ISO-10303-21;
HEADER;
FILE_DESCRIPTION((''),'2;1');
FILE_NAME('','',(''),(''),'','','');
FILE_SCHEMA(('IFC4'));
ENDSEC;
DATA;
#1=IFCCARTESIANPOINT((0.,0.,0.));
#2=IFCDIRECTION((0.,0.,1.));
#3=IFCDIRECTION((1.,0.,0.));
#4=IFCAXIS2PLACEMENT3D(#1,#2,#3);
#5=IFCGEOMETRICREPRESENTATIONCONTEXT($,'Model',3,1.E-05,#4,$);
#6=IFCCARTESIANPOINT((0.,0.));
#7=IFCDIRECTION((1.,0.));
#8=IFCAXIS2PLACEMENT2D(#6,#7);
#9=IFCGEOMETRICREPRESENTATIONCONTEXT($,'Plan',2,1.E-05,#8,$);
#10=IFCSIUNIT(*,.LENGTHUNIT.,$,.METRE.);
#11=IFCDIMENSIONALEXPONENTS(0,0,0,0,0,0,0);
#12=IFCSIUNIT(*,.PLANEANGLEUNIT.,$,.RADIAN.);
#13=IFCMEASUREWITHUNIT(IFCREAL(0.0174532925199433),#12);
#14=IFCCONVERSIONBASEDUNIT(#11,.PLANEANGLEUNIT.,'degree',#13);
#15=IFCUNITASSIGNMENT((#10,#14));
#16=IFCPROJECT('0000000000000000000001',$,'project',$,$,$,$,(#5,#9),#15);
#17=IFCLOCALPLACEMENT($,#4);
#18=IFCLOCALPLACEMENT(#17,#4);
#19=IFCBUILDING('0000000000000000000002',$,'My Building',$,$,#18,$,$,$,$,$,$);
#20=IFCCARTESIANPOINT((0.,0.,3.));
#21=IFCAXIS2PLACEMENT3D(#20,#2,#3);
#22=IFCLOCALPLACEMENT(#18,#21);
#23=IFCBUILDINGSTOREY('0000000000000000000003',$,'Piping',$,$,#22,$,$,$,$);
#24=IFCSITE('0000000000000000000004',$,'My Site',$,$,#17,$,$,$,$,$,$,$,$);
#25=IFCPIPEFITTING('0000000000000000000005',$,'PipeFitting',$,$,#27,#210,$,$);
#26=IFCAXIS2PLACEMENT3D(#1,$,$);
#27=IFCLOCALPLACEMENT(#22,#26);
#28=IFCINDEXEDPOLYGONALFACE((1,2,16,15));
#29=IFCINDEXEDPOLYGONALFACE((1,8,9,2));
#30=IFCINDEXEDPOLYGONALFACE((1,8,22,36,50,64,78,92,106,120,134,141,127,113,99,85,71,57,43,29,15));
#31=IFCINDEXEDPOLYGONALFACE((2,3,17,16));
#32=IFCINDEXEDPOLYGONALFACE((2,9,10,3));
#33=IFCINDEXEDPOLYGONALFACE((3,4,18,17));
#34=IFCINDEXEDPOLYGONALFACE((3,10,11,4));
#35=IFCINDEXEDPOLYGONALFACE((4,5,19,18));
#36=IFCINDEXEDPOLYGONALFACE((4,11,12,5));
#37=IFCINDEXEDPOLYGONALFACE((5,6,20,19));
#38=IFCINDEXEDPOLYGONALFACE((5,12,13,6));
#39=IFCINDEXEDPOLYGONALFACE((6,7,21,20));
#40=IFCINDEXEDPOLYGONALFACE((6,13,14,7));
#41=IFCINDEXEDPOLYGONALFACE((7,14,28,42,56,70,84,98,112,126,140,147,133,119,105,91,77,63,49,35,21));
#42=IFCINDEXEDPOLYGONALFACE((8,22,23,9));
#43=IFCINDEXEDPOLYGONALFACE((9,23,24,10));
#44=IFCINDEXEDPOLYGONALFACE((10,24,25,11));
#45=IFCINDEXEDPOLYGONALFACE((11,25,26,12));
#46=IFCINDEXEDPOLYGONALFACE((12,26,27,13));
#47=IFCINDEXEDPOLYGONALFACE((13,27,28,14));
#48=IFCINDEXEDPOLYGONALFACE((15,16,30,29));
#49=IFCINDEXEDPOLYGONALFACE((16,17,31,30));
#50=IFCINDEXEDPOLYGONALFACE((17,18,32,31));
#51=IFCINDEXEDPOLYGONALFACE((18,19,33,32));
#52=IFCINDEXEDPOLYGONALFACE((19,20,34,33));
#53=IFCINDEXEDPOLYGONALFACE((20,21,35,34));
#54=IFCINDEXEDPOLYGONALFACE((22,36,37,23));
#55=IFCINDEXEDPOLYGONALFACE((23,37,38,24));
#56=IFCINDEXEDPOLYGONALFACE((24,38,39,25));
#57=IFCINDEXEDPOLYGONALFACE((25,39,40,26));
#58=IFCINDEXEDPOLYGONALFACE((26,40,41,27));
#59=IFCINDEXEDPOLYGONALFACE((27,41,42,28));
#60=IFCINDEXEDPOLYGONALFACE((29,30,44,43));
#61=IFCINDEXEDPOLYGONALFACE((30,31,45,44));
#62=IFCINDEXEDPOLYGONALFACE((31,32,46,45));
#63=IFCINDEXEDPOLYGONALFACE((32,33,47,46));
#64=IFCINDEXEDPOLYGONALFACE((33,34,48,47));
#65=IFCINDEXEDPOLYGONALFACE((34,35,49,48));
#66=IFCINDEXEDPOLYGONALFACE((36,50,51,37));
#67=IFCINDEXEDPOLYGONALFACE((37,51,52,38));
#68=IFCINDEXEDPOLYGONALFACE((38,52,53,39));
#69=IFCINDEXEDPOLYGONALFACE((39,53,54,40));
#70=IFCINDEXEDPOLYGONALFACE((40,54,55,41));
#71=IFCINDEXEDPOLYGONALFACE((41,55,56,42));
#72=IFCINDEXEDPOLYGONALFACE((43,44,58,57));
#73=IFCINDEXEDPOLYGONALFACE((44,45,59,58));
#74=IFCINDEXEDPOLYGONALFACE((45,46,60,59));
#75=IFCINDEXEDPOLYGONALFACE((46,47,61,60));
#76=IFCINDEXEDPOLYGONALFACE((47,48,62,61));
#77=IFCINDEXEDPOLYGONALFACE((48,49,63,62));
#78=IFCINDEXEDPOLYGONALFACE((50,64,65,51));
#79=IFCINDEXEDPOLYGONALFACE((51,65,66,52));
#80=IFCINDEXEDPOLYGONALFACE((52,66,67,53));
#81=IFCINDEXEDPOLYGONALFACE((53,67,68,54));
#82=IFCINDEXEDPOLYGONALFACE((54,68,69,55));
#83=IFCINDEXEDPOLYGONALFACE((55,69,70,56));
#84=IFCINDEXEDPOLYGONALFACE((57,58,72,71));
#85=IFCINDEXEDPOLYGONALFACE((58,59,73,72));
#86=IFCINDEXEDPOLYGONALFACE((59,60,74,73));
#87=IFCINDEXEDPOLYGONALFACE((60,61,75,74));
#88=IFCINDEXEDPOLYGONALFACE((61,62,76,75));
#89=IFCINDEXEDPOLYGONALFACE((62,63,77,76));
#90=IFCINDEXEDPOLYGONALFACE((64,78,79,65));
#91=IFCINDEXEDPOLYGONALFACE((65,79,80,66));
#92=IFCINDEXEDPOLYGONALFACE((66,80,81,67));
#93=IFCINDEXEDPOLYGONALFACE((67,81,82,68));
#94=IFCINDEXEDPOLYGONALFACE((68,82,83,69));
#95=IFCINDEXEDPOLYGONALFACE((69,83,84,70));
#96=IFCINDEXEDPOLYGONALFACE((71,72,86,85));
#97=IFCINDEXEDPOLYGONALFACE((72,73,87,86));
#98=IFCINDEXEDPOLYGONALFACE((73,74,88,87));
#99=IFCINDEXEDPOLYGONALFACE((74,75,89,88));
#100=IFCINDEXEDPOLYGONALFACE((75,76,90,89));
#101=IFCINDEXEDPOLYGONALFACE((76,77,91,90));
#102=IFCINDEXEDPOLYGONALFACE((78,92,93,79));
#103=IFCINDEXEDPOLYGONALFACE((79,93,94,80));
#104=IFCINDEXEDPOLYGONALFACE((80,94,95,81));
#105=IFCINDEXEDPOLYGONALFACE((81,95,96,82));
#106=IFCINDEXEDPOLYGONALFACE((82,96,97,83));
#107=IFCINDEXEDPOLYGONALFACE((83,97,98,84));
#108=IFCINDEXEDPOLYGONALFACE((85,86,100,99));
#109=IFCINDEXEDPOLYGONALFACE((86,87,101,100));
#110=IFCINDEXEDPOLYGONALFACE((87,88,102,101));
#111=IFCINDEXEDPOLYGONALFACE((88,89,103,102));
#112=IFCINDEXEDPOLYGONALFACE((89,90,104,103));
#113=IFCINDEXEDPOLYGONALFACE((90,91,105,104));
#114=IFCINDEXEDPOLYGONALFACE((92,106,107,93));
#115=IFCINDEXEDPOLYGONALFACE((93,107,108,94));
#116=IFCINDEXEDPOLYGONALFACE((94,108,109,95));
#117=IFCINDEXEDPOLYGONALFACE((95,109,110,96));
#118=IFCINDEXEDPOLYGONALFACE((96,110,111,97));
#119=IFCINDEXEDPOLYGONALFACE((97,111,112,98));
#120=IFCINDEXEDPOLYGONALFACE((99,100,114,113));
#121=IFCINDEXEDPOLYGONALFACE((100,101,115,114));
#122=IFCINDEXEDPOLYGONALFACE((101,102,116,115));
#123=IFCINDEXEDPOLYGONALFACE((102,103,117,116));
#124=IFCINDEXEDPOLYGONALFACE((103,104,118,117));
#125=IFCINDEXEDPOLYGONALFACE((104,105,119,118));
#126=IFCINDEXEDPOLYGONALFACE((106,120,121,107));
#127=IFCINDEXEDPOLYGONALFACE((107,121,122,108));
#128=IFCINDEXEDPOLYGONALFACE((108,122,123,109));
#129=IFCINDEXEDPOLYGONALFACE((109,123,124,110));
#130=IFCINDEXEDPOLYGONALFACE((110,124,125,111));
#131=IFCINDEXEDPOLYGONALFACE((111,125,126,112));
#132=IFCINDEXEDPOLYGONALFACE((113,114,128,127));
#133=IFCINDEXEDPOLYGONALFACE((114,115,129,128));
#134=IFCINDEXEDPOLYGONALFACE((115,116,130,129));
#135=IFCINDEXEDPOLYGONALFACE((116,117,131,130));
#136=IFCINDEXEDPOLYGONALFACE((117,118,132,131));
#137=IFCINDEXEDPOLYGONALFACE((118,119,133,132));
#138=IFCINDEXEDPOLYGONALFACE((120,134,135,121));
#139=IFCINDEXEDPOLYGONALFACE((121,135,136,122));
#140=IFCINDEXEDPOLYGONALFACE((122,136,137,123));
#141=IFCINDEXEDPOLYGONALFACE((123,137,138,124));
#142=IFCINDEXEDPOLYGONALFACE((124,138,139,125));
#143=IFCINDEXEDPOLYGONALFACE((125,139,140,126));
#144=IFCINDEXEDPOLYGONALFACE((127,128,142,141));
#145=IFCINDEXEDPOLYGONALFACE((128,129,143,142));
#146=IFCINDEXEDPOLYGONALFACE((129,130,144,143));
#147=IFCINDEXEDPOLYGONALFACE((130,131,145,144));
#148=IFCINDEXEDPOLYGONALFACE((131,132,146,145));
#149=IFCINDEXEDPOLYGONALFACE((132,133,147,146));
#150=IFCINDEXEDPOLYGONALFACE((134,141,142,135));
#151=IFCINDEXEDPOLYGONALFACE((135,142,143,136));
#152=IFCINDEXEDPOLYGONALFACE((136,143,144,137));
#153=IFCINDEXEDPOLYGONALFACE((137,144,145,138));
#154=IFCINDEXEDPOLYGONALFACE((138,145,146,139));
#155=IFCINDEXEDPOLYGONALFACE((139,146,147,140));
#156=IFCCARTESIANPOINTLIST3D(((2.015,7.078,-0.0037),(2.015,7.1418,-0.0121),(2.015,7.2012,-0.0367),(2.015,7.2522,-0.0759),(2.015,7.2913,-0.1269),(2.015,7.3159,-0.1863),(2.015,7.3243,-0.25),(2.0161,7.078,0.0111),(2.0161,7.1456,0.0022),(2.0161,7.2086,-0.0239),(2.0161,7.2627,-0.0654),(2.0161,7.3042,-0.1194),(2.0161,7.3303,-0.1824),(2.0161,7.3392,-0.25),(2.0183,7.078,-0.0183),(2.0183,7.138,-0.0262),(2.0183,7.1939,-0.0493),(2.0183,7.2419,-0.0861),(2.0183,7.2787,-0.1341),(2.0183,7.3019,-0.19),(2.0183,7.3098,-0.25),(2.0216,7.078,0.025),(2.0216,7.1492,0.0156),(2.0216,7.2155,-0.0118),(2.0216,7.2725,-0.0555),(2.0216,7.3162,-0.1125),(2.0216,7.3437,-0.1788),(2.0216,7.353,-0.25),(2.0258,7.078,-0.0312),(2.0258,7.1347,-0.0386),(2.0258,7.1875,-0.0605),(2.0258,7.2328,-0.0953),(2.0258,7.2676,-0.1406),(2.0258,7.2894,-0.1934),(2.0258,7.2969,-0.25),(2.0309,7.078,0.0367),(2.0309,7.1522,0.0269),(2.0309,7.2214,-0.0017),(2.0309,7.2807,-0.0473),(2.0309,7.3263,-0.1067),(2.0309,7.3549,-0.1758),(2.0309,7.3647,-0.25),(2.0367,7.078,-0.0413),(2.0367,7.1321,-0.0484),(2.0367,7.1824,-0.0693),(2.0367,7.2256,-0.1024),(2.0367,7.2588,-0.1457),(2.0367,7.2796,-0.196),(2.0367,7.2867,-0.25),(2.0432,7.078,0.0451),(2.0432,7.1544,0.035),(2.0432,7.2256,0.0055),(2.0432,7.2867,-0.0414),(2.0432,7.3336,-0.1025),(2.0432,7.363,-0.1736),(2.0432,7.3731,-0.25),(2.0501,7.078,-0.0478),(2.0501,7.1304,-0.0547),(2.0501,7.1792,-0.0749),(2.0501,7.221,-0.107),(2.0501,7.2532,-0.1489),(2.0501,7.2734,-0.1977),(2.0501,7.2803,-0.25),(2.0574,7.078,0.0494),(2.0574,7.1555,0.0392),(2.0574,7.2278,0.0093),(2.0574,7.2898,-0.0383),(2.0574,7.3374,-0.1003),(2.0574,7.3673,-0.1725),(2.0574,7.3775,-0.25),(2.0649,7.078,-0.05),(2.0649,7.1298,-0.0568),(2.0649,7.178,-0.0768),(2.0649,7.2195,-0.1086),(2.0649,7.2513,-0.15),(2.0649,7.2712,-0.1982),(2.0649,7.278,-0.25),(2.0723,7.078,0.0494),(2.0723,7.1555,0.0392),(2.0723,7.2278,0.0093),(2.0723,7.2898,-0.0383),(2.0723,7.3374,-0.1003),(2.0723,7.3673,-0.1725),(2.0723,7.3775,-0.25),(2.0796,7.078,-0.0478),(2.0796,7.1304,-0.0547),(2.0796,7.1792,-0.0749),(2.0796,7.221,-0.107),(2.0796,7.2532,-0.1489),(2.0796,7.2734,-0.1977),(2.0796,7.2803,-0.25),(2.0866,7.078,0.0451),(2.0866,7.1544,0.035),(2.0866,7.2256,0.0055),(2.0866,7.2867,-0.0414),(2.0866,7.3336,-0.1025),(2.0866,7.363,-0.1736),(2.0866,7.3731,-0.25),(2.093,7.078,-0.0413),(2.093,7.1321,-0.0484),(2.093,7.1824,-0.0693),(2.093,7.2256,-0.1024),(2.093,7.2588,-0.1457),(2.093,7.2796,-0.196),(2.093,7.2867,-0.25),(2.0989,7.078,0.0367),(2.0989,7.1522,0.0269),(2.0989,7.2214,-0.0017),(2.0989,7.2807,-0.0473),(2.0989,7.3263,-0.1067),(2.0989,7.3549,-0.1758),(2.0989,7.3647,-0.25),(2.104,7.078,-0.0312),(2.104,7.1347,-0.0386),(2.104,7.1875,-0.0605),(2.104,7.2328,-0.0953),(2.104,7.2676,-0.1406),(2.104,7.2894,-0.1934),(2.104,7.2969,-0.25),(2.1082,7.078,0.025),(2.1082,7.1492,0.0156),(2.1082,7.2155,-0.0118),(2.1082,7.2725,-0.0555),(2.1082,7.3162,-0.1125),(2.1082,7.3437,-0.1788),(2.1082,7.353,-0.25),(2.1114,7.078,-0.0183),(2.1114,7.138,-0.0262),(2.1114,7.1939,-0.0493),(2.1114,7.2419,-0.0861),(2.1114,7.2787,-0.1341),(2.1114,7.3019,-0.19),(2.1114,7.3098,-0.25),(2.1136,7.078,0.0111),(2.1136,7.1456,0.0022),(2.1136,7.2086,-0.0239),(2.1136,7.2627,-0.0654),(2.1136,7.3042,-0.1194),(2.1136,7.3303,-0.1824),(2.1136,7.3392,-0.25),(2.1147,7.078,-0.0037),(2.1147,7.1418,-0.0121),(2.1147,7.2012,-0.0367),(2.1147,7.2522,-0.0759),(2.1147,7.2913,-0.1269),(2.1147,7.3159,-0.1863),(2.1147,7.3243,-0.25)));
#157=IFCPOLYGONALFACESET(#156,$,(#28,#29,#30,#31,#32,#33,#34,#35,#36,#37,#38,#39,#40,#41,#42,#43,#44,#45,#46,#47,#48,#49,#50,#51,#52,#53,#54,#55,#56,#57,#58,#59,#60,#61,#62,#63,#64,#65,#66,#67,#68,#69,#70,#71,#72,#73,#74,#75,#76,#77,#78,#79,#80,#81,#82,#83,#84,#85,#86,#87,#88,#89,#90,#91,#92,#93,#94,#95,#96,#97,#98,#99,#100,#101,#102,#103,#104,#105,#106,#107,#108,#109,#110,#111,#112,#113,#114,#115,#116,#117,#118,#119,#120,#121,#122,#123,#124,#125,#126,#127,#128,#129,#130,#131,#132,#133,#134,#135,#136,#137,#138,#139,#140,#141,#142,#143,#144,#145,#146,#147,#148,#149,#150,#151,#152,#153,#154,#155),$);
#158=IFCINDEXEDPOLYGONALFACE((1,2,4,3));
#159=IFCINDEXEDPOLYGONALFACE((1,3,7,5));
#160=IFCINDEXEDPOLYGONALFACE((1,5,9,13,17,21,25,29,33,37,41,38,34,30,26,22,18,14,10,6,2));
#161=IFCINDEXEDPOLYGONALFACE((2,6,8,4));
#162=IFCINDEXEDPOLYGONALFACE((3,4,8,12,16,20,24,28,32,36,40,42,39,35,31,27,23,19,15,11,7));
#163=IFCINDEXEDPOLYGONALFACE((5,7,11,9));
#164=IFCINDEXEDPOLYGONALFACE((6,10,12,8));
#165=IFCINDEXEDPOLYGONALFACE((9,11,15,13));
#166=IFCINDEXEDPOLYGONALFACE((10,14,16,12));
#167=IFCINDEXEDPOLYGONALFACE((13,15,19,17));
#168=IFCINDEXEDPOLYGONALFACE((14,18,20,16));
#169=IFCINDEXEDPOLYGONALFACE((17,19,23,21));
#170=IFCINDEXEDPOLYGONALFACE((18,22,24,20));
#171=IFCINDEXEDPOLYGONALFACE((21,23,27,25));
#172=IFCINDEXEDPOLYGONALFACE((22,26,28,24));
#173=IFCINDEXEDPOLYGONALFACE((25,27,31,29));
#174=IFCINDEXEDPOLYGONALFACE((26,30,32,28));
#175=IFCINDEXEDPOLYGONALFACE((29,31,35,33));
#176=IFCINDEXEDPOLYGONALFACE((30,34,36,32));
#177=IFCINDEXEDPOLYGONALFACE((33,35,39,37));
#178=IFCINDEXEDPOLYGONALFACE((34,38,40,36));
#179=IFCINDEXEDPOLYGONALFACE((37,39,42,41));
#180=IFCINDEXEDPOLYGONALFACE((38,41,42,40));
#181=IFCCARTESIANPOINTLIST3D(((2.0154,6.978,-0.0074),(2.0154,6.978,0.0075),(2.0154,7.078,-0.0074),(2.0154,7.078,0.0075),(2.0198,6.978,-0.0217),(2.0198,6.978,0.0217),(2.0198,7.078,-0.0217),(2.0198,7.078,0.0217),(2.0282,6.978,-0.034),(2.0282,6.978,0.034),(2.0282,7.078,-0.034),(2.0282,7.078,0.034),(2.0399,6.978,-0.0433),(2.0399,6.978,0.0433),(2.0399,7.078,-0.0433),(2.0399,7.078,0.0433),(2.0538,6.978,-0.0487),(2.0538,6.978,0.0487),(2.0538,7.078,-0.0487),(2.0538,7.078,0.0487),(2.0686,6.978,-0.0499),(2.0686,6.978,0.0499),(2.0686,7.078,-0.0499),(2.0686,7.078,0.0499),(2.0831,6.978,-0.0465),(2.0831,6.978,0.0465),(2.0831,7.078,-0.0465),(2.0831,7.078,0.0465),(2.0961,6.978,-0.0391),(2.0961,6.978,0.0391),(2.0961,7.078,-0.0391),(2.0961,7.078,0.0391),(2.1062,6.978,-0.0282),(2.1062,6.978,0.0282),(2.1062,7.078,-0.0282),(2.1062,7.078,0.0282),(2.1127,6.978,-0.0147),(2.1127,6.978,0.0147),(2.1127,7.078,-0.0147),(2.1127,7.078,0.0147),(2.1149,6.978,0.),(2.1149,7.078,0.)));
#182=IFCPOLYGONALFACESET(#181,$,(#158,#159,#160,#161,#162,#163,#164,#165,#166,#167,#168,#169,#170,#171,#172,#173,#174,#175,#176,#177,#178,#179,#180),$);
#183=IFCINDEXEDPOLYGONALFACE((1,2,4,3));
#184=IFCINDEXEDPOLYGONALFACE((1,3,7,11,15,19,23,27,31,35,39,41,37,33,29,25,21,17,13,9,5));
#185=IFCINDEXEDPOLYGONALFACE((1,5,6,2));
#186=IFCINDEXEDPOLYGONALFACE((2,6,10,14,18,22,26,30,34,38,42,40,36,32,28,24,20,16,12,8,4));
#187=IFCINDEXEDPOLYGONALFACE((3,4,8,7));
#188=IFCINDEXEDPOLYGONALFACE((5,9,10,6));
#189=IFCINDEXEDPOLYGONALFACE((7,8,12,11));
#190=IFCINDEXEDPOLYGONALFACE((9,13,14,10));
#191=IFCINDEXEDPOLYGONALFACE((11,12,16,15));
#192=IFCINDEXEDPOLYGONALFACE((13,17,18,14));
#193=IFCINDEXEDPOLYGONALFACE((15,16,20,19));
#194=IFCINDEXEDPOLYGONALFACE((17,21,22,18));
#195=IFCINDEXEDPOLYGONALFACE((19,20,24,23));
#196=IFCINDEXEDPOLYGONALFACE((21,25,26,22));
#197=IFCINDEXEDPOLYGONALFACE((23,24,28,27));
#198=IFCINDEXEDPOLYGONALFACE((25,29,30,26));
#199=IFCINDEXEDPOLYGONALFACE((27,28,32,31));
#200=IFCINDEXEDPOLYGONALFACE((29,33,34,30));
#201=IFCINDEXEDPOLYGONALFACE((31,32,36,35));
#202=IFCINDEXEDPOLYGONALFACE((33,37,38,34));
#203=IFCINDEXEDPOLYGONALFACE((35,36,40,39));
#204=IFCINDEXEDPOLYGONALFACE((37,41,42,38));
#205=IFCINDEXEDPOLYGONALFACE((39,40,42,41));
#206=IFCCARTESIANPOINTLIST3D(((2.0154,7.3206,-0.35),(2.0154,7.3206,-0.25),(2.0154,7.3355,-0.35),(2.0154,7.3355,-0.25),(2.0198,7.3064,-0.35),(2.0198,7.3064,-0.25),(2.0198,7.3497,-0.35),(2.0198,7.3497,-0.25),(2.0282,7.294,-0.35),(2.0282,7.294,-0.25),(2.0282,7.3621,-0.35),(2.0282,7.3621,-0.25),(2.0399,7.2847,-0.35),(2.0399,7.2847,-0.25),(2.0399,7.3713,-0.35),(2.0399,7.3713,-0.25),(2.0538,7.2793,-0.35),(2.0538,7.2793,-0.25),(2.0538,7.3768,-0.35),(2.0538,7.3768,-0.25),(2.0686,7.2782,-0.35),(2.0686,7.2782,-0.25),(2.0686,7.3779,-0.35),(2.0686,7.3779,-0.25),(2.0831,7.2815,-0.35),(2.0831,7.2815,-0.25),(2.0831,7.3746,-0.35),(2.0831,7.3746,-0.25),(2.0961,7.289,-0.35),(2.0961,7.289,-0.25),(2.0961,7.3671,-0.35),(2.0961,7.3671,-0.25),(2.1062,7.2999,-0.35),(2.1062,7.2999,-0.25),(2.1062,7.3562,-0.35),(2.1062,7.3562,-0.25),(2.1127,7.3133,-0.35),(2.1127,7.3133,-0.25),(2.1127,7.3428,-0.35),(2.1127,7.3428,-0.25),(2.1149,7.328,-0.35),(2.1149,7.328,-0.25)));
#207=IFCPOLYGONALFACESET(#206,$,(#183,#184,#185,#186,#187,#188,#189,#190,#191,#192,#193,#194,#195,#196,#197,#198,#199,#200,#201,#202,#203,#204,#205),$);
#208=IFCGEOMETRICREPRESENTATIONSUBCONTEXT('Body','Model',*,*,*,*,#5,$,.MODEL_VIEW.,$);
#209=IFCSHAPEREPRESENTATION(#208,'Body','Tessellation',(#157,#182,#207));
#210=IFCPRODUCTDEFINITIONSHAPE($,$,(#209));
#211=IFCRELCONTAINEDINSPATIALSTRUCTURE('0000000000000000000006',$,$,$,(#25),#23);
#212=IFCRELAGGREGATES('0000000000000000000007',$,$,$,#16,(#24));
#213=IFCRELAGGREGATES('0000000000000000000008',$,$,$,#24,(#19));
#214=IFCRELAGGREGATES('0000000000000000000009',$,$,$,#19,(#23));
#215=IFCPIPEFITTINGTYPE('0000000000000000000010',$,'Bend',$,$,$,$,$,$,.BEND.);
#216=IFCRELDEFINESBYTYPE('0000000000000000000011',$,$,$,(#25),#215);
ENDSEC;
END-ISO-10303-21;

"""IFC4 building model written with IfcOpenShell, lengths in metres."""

from ifc_helpers import new_model, entity, si_unit, converted_unit, frame, origin_with_axes, origin_2d_with_axis, place, context, subcontext, project, spatial, circle, extrude, source, transform, mapped, type_object, type_shapes, element, save


model = new_model("IFC4")

# Units and contexts
model_context = context("Model", 3, precision=1e-05, world=origin_with_axes())
plan_context = context("Plan", 2, precision=1e-05, world=origin_2d_with_axis())
body_context = subcontext(model_context, "Body", "Model", "MODEL_VIEW")
ifc_project = project(units=[si_unit("LENGTHUNIT", "METRE"), converted_unit("PLANEANGLEUNIT", "degree", entity("IfcReal", 0.0174532925199433), si_unit("PLANEANGLEUNIT", "RADIAN"), dimensions=[0, 0, 0, 0, 0, 0, 0])], contexts=[model_context, plan_context])

# Site, building, storey
site_placement = place(None, origin_with_axes())
site = spatial("IfcSite", under=ifc_project, at=site_placement, Name="My Site")
building_placement = place(site_placement, origin_with_axes())
building = spatial("IfcBuilding", under=site, at=building_placement, Name="My Building")
storey_placement = place(building_placement, frame((0.0, 0.0, 3.0), z_axis=(0.0, 0.0, 1.0), x_axis=(1.0, 0.0, 0.0)))
storey = spatial("IfcBuildingStorey", under=building, at=storey_placement, Name="Piping")

# Pipe fitting
pipe_fitting_type_1 = type_object("IfcPipeFittingType", Name="Bend", PredefinedType="BEND")
shared_shape = source(origin_with_axes(), body_context, "Body", "SolidModel", [
    entity("IfcSweptDiskSolid", entity("IfcIndexedPolyCurve", entity("IfcCartesianPointList3D", [[0.0, 0.0, -0.1], [0.0, -0.0732, -0.2768], [0.0, -0.25, -0.35]]), [entity("IfcArcIndex", [1, 2, 3])]), 0.05),
    extrude(circle(Radius=0.05), origin_with_axes(), (0.0, 0.0, -1.0), 0.1),
    extrude(circle(Radius=0.05), frame((0.0, -0.25, -0.35), z_axis=(0.0, -1.0, 0.0), x_axis=(1.0, 0.0, 0.0)), (0.0, 0.0, 1.0), 0.1),
])
type_shapes(pipe_fitting_type_1, [shared_shape])
for number, where, z_axis, x_axis, name in (
    (1, (2.0649, 6.978, 0.0), (0.0, -1.0, 0.0), (1.0, 0.0, 0.0), "PipeFitting"),
):
    element("IfcPipeFitting", number, at=place(storey_placement, frame(where, z_axis=z_axis, x_axis=x_axis)), inside=storey, type_object=pipe_fitting_type_1, Name=name, context=body_context, shape_type="MappedRepresentation", body=[
        mapped(shared_shape, transform((0.0, 0.0, 0.0), x_axis=(1.0, 0.0, 0.0), y_axis=(0.0, 1.0, 0.0), z_axis=(0.0, 0.0, 1.0), scale=1.0)),
    ])

save(model, "model.ifc")
